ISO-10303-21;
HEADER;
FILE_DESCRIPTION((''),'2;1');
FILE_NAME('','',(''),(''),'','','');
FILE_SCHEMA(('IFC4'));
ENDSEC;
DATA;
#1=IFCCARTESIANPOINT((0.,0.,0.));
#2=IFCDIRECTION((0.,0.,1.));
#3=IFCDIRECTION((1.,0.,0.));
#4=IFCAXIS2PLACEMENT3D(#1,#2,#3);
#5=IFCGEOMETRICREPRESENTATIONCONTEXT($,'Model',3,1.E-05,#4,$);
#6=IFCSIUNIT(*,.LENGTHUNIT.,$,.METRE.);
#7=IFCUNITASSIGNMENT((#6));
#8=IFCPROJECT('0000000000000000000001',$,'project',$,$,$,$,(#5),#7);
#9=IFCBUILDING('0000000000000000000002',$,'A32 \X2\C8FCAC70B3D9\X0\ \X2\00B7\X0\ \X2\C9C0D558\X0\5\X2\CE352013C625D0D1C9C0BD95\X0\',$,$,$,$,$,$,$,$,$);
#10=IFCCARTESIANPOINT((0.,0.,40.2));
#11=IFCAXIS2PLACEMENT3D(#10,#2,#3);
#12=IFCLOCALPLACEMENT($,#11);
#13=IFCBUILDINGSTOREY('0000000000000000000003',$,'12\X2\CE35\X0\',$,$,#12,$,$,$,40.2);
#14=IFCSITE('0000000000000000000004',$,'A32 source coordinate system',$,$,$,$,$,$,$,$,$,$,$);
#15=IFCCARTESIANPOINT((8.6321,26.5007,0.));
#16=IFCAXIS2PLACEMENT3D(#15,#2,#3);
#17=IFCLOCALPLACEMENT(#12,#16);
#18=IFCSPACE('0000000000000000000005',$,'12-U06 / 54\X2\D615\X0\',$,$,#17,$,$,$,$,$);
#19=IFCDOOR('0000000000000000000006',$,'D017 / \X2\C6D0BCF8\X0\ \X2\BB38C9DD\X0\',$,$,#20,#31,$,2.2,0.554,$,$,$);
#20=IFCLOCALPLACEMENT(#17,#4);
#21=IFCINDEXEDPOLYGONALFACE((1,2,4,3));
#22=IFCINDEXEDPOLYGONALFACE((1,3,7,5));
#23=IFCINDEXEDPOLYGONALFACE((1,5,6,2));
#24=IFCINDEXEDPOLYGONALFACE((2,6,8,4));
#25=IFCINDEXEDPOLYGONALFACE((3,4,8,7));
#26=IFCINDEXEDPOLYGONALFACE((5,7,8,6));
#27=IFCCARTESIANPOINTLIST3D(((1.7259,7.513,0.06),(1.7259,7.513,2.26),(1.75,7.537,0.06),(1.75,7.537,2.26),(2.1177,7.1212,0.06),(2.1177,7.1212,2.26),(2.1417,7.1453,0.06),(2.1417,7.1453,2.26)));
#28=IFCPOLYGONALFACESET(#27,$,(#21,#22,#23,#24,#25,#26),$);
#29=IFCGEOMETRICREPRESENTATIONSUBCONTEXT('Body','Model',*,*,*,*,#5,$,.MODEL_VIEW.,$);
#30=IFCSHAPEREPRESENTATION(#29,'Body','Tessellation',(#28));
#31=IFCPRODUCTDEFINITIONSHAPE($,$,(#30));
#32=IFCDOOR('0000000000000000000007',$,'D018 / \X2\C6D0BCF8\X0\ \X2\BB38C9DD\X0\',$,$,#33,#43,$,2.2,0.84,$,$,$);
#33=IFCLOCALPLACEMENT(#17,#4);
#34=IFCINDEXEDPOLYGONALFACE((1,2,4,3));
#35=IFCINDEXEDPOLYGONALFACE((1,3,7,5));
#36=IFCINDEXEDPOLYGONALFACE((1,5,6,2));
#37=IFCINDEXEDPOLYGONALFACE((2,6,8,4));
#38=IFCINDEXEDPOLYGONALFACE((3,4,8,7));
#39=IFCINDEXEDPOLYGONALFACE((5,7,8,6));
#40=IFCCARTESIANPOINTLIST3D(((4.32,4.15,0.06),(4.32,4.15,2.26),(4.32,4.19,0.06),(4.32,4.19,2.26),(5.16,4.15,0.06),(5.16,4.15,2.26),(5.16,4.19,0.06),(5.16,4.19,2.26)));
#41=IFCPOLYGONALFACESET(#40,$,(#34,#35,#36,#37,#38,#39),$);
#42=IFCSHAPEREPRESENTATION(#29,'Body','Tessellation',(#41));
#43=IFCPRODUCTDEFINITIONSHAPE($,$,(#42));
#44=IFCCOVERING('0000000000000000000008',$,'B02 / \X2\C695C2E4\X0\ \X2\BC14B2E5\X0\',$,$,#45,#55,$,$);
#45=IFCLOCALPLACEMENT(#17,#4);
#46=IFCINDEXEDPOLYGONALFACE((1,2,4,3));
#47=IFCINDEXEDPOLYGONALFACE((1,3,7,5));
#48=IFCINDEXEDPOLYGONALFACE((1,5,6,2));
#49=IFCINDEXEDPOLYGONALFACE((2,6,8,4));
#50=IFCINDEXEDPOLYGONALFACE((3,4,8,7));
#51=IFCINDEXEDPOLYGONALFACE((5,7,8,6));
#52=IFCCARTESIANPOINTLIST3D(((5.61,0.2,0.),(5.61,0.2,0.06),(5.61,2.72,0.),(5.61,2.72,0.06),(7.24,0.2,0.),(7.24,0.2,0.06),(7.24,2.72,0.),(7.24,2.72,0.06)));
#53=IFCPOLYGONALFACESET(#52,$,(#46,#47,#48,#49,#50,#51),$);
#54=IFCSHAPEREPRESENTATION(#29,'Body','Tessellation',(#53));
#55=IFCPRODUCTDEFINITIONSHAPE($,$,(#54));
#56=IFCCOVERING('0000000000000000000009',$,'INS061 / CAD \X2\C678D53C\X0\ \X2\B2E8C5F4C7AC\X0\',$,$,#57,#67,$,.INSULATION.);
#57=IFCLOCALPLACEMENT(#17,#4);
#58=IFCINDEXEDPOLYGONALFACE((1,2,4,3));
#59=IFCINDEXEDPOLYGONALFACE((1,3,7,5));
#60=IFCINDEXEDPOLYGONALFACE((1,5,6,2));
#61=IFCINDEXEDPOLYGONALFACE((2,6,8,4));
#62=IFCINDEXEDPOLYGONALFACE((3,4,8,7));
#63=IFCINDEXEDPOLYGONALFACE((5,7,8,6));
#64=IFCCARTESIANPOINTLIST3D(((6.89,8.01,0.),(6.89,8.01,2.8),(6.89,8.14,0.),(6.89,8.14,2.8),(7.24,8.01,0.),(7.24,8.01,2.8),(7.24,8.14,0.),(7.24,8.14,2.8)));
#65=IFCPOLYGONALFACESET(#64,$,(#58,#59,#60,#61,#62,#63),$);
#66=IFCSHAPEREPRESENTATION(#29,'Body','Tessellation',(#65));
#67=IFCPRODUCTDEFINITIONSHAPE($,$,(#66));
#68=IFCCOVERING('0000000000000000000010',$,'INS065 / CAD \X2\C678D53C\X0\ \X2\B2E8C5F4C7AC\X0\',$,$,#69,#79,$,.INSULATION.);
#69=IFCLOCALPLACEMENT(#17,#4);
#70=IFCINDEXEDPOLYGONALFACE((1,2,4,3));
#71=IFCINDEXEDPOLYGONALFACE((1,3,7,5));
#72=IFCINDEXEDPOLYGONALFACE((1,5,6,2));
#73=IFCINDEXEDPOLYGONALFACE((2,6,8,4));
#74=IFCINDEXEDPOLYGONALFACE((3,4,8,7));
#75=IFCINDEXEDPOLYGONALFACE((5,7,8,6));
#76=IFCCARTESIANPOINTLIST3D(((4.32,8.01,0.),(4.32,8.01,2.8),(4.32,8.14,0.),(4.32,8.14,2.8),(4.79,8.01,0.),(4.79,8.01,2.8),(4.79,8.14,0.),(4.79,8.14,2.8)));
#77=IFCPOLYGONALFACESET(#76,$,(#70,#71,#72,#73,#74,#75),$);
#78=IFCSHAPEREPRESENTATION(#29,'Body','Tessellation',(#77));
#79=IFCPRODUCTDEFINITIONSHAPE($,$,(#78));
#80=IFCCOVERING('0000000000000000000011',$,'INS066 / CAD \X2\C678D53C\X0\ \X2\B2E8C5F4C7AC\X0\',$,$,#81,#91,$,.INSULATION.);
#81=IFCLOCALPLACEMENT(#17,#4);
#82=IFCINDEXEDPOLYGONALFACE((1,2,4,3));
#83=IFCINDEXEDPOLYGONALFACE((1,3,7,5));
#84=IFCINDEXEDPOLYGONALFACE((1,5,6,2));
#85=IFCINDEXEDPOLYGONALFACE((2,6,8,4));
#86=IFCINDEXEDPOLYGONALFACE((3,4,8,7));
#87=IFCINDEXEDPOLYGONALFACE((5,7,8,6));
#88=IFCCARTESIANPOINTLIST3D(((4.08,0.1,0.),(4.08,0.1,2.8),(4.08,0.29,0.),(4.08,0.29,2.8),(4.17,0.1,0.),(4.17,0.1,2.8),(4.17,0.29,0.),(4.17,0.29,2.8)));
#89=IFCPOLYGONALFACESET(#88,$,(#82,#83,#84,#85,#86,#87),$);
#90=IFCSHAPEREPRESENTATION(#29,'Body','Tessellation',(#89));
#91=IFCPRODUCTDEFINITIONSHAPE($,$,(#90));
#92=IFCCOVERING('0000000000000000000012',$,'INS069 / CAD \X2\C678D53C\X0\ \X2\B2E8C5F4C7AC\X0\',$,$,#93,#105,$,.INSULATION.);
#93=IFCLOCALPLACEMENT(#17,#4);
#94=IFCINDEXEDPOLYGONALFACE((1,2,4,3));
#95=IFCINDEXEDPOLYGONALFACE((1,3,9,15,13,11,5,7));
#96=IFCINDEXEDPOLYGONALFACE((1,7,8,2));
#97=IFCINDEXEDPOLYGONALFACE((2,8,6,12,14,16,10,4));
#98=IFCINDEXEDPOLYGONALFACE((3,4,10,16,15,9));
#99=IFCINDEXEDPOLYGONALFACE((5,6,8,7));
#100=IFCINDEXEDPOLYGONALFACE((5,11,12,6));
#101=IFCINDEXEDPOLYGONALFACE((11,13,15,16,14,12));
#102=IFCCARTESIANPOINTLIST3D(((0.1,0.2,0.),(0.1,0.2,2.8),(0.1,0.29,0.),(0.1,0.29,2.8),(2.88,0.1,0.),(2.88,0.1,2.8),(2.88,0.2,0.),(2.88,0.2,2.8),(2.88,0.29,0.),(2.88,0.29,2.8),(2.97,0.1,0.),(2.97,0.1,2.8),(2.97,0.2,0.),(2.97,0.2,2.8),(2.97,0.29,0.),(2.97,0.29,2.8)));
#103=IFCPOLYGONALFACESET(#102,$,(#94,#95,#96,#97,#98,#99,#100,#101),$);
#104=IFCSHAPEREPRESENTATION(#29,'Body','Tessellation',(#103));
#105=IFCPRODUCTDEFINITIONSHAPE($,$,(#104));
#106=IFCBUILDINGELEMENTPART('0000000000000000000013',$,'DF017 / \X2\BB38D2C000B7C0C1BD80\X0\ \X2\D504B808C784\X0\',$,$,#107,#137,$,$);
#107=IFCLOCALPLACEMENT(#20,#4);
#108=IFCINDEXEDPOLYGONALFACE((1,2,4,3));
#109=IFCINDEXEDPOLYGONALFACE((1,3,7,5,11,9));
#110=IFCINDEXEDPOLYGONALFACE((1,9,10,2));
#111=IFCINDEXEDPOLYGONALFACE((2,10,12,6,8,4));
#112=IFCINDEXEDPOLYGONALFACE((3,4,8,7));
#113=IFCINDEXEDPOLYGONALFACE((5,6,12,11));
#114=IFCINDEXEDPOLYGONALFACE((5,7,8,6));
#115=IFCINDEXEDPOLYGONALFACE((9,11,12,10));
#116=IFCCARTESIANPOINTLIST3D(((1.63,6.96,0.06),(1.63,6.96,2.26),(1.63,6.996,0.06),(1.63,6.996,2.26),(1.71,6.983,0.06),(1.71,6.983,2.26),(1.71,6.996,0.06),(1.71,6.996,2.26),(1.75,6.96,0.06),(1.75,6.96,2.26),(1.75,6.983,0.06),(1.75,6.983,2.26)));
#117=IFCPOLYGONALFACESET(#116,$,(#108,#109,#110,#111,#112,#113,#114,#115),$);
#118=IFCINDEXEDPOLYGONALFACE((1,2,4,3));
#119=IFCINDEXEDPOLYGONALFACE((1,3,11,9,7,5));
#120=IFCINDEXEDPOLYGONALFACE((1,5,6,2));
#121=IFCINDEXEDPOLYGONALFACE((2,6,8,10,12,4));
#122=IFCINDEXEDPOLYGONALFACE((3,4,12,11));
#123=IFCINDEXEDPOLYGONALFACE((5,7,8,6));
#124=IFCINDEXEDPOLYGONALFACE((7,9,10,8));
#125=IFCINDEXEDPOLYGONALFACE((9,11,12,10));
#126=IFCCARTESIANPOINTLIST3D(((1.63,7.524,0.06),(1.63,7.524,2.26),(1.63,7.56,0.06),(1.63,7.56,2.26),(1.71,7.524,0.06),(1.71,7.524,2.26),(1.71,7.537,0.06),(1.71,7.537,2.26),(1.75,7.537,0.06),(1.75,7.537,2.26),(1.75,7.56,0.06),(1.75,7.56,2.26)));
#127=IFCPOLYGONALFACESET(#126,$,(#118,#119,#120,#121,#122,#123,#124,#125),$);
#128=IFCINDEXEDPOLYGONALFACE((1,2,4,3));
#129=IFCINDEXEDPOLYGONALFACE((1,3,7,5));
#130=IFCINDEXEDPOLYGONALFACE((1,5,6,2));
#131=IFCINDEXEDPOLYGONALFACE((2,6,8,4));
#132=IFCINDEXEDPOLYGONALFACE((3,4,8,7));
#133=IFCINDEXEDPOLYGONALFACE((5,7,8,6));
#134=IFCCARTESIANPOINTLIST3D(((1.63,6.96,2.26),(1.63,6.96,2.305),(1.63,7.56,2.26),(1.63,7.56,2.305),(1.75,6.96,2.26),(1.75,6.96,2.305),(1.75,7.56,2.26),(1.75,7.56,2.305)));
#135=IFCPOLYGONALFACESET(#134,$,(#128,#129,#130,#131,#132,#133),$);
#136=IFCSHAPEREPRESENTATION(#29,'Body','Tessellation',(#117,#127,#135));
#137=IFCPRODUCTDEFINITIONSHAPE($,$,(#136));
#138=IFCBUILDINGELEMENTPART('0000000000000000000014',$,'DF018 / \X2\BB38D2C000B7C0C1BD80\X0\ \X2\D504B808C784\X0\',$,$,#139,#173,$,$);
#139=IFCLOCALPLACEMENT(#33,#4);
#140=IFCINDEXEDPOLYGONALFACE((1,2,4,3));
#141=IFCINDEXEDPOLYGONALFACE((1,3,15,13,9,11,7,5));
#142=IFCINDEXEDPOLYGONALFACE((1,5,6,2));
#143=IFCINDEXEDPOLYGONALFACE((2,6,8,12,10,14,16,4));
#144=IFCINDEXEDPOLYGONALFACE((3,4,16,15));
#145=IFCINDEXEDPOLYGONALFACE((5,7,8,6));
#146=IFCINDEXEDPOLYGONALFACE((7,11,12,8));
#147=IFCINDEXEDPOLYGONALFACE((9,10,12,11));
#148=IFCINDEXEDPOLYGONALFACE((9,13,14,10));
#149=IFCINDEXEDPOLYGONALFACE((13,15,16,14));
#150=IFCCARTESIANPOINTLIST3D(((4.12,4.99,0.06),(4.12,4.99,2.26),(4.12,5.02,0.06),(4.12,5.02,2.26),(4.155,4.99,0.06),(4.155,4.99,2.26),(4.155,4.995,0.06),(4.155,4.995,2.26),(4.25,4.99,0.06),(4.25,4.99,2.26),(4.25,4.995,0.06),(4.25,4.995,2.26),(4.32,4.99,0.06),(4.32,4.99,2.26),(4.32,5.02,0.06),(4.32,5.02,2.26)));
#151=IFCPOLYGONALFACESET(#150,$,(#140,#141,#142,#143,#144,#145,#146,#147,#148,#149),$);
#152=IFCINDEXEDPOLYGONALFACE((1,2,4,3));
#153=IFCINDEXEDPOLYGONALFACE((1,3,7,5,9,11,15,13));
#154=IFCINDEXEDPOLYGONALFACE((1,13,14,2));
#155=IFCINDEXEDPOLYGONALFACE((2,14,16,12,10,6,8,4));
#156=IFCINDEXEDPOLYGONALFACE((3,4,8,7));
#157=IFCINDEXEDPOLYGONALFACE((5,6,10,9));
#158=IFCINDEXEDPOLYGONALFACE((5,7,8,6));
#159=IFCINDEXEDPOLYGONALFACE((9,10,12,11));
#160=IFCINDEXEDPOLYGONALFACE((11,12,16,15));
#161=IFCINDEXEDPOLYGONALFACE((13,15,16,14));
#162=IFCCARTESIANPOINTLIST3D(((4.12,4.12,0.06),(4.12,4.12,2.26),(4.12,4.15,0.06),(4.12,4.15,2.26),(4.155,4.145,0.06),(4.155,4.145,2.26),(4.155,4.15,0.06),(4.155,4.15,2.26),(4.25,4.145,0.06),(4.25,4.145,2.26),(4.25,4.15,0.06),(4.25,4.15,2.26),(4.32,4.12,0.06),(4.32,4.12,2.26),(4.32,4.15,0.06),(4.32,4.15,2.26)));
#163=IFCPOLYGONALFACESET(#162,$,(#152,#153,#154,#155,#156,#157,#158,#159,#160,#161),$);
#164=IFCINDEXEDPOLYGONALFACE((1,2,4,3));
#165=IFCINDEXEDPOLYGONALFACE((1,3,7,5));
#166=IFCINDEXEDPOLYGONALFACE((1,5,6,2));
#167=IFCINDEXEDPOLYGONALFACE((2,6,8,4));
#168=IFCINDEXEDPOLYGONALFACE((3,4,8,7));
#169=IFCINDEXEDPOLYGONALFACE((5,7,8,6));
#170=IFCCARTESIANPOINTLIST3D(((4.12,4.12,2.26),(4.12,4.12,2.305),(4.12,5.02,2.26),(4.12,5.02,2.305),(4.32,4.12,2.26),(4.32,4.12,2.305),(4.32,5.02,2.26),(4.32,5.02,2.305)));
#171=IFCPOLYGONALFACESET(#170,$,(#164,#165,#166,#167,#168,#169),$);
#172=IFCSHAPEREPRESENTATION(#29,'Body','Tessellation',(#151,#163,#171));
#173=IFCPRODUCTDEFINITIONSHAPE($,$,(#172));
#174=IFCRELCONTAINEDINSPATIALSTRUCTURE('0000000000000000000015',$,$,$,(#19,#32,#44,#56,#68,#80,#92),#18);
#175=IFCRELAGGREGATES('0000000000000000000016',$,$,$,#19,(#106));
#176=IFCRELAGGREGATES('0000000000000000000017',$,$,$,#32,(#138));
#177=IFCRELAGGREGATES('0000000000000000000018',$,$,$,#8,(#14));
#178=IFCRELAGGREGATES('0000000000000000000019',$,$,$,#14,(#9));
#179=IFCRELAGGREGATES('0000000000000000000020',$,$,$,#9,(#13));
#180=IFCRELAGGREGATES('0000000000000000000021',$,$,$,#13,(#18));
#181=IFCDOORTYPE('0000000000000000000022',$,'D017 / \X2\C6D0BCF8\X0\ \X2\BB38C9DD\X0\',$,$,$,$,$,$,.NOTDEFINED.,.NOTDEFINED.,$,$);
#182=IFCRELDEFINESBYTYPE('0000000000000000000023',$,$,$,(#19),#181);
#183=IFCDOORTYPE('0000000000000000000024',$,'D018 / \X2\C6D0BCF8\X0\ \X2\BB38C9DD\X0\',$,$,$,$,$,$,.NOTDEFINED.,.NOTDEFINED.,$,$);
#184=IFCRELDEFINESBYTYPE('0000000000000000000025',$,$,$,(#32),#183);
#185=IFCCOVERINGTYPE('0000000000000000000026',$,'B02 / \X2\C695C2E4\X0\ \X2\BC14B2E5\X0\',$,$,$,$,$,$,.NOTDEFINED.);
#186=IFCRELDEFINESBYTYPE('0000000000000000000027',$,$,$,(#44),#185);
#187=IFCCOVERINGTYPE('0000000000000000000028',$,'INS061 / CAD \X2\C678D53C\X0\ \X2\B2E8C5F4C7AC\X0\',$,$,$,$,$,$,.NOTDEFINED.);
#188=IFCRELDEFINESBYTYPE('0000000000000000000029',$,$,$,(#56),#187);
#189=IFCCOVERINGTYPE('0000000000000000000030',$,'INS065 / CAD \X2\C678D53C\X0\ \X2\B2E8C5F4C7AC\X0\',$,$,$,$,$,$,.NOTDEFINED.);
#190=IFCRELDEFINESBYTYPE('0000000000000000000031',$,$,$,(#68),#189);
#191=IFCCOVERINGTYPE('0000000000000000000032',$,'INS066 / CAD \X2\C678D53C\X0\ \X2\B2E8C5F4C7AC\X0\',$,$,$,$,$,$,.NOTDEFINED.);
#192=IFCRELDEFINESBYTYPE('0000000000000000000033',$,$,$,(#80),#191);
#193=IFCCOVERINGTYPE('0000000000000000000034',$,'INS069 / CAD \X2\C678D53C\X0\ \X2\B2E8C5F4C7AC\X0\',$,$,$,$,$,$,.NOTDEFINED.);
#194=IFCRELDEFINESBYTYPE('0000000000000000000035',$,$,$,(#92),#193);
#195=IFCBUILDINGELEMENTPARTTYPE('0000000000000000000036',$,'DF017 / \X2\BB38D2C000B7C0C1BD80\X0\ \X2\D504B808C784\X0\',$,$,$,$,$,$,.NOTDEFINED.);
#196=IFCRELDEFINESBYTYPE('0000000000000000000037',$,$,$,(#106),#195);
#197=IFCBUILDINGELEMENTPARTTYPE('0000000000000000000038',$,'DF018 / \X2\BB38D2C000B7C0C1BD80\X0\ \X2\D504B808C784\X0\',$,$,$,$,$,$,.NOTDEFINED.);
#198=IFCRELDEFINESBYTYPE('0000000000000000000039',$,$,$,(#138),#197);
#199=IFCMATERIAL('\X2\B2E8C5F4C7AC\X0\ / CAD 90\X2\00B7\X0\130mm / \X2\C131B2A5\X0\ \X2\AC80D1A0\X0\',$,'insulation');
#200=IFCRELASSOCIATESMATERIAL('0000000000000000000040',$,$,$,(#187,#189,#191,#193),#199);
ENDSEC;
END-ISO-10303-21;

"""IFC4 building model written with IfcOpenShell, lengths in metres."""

from ifc_helpers import new_model, si_unit, frame, origin, origin_with_axes, place, context, subcontext, project, spatial, polyline, outline, extrude, source, transform, mapped, material, type_object, type_shapes, element, aggregate, save


model = new_model("IFC4")

# Units and contexts
model_context = context("Model", 3, precision=1e-05, world=origin_with_axes())
body_context = subcontext(model_context, "Body", "Model", "MODEL_VIEW")
ifc_project = project(units=[si_unit("LENGTHUNIT", "METRE")], contexts=[model_context])

# Site, building, storey, space
storey_placement = place(None, frame((0.0, 0.0, 40.2), z_axis=(0.0, 0.0, 1.0), x_axis=(1.0, 0.0, 0.0)))
space_1_placement = place(storey_placement, frame((8.6321, 26.5007, 0.0), z_axis=(0.0, 0.0, 1.0), x_axis=(1.0, 0.0, 0.0)))
site = spatial("IfcSite", under=ifc_project, Name="A32 source coordinate system")
building = spatial("IfcBuilding", under=site, Name="A32 주거동 · 지하5층–옥탑지붕")
storey = spatial("IfcBuildingStorey", under=building, at=storey_placement, Name="12층", Elevation=40.2)
space_1 = spatial("IfcSpace", under=storey, at=space_1_placement, Name="12-U06 / 54형")

# Doors
door_type_1 = type_object("IfcDoorType", Name="D017 / 원본 문짝", OperationType="NOTDEFINED", PredefinedType="NOTDEFINED")
shared_shape_1 = source(origin(), body_context, "Body", "SweptSolid", [
    extrude(outline(polyline([(1.75, 7.537), (2.1417, 7.1453), (2.1177, 7.1212), (1.7259, 7.513), (1.75, 7.537)])), frame((0.0, 0.0, 0.06)), (0.0, 0.0, 1.0), 2.2),
])
type_shapes(door_type_1, [shared_shape_1])
door_1_placement = place(space_1_placement, origin_with_axes())
door_1 = element("IfcDoor", 1, at=door_1_placement, inside=space_1, type_object=door_type_1, Name="D017 / 원본 문짝", OverallHeight=2.2, OverallWidth=0.554, context=body_context, shape_type="MappedRepresentation", body=[
    mapped(shared_shape_1, transform((0.0, 0.0, 0.0), scale=1.0)),
])
door_type_2 = type_object("IfcDoorType", Name="D018 / 원본 문짝", OperationType="NOTDEFINED", PredefinedType="NOTDEFINED")
shared_shape_2 = source(origin(), body_context, "Body", "SweptSolid", [
    extrude(outline(polyline([(5.16, 4.19), (5.16, 4.15), (4.32, 4.15), (4.32, 4.19), (5.16, 4.19)])), frame((0.0, 0.0, 0.06)), (0.0, 0.0, 1.0), 2.2),
])
type_shapes(door_type_2, [shared_shape_2])
door_2_placement = place(space_1_placement, origin_with_axes())
door_2 = element("IfcDoor", 2, at=door_2_placement, inside=space_1, type_object=door_type_2, Name="D018 / 원본 문짝", OverallHeight=2.2, OverallWidth=0.84, context=body_context, shape_type="MappedRepresentation", body=[
    mapped(shared_shape_2, transform((0.0, 0.0, 0.0), scale=1.0)),
])

# Coverings
covering_type_1 = type_object("IfcCoveringType", Name="B02 / 욕실 바닥", PredefinedType="NOTDEFINED")
shared_shape_3 = source(origin(), body_context, "Body", "SweptSolid", [
    extrude(outline(polyline([(5.61, 2.72), (7.24, 2.72), (7.24, 0.2), (5.61, 0.2), (5.61, 2.72)])), origin(), (0.0, 0.0, 1.0), 0.06),
])
type_shapes(covering_type_1, [shared_shape_3])
covering_1_placement = place(space_1_placement, origin_with_axes())
element("IfcCovering", 3, at=covering_1_placement, inside=space_1, type_object=covering_type_1, Name="B02 / 욕실 바닥", context=body_context, shape_type="MappedRepresentation", body=[
    mapped(shared_shape_3, transform((0.0, 0.0, 0.0), scale=1.0)),
])
ifc_material = material(Name="단열재 / CAD 90·130mm / 성능 검토", Category="insulation")
covering_type_2 = type_object("IfcCoveringType", Name="INS061 / CAD 외피 단열재", PredefinedType="NOTDEFINED", material=ifc_material)
shared_shape_4 = source(origin(), body_context, "Body", "SweptSolid", [
    extrude(outline(polyline([(6.89, 8.01), (6.89, 8.14), (7.24, 8.14), (7.24, 8.01), (6.89, 8.01)])), origin(), (0.0, 0.0, 1.0), 2.8),
])
type_shapes(covering_type_2, [shared_shape_4])
covering_2_placement = place(space_1_placement, origin_with_axes())
element("IfcCovering", 4, at=covering_2_placement, inside=space_1, type_object=covering_type_2, Name="INS061 / CAD 외피 단열재", PredefinedType="INSULATION", context=body_context, shape_type="MappedRepresentation", body=[
    mapped(shared_shape_4, transform((0.0, 0.0, 0.0), scale=1.0)),
])
covering_type_3 = type_object("IfcCoveringType", Name="INS065 / CAD 외피 단열재", PredefinedType="NOTDEFINED", material=ifc_material)
shared_shape_5 = source(origin(), body_context, "Body", "SweptSolid", [
    extrude(outline(polyline([(4.32, 8.01), (4.32, 8.14), (4.79, 8.14), (4.79, 8.01), (4.32, 8.01)])), origin(), (0.0, 0.0, 1.0), 2.8),
])
type_shapes(covering_type_3, [shared_shape_5])
covering_3_placement = place(space_1_placement, origin_with_axes())
element("IfcCovering", 5, at=covering_3_placement, inside=space_1, type_object=covering_type_3, Name="INS065 / CAD 외피 단열재", PredefinedType="INSULATION", context=body_context, shape_type="MappedRepresentation", body=[
    mapped(shared_shape_5, transform((0.0, 0.0, 0.0), scale=1.0)),
])
covering_type_4 = type_object("IfcCoveringType", Name="INS066 / CAD 외피 단열재", PredefinedType="NOTDEFINED", material=ifc_material)
shared_shape_6 = source(origin(), body_context, "Body", "SweptSolid", [
    extrude(outline(polyline([(4.08, 0.29), (4.17, 0.29), (4.17, 0.1), (4.08, 0.1), (4.08, 0.29)])), origin(), (0.0, 0.0, 1.0), 2.8),
])
type_shapes(covering_type_4, [shared_shape_6])
covering_4_placement = place(space_1_placement, origin_with_axes())
element("IfcCovering", 6, at=covering_4_placement, inside=space_1, type_object=covering_type_4, Name="INS066 / CAD 외피 단열재", PredefinedType="INSULATION", context=body_context, shape_type="MappedRepresentation", body=[
    mapped(shared_shape_6, transform((0.0, 0.0, 0.0), scale=1.0)),
])
covering_type_5 = type_object("IfcCoveringType", Name="INS069 / CAD 외피 단열재", PredefinedType="NOTDEFINED", material=ifc_material)
shared_shape_7 = source(origin(), body_context, "Body", "SweptSolid", [
    extrude(outline(polyline([(2.97, 0.1), (2.88, 0.1), (2.88, 0.2), (0.1, 0.2), (0.1, 0.29), (2.88, 0.29), (2.97, 0.29), (2.97, 0.2), (2.97, 0.1)])), origin(), (0.0, 0.0, 1.0), 2.8),
])
type_shapes(covering_type_5, [shared_shape_7])
covering_5_placement = place(space_1_placement, origin_with_axes())
element("IfcCovering", 7, at=covering_5_placement, inside=space_1, type_object=covering_type_5, Name="INS069 / CAD 외피 단열재", PredefinedType="INSULATION", context=body_context, shape_type="MappedRepresentation", body=[
    mapped(shared_shape_7, transform((0.0, 0.0, 0.0), scale=1.0)),
])

# Building element parts
building_element_part_type_1 = type_object("IfcBuildingElementPartType", Name="DF017 / 문틀·상부 프레임", PredefinedType="NOTDEFINED")
shared_shape_8 = source(origin(), body_context, "Body", "SweptSolid", [
    extrude(outline(polyline([(1.63, 6.996), (1.71, 6.996), (1.71, 6.983), (1.75, 6.983), (1.75, 6.96), (1.63, 6.96), (1.63, 6.996)])), frame((0.0, 0.0, 0.06)), (0.0, 0.0, 1.0), 2.2),
    extrude(outline(polyline([(1.75, 7.56), (1.75, 7.537), (1.71, 7.537), (1.71, 7.524), (1.63, 7.524), (1.63, 7.56), (1.75, 7.56)])), frame((0.0, 0.0, 0.06)), (0.0, 0.0, 1.0), 2.2),
    extrude(outline(polyline([(1.63, 6.96), (1.63, 7.56), (1.75, 7.56), (1.75, 6.96), (1.63, 6.96)])), frame((0.0, 0.0, 2.26)), (0.0, 0.0, 1.0), 0.045),
])
type_shapes(building_element_part_type_1, [shared_shape_8])
building_element_part_1_placement = place(door_1_placement, origin_with_axes())
building_element_part_1 = element("IfcBuildingElementPart", 8, at=building_element_part_1_placement, type_object=building_element_part_type_1, Name="DF017 / 문틀·상부 프레임", context=body_context, shape_type="MappedRepresentation", body=[
    mapped(shared_shape_8, transform((0.0, 0.0, 0.0), scale=1.0)),
])
aggregate(door_1, [building_element_part_1])
building_element_part_type_2 = type_object("IfcBuildingElementPartType", Name="DF018 / 문틀·상부 프레임", PredefinedType="NOTDEFINED")
shared_shape_9 = source(origin(), body_context, "Body", "SweptSolid", [
    extrude(outline(polyline([(4.32, 4.99), (4.25, 4.99), (4.25, 4.995), (4.155, 4.995), (4.155, 4.99), (4.12, 4.99), (4.12, 5.02), (4.32, 5.02), (4.32, 4.99)])), frame((0.0, 0.0, 0.06)), (0.0, 0.0, 1.0), 2.2),
    extrude(outline(polyline([(4.12, 4.12), (4.12, 4.15), (4.155, 4.15), (4.155, 4.145), (4.25, 4.145), (4.25, 4.15), (4.32, 4.15), (4.32, 4.12), (4.12, 4.12)])), frame((0.0, 0.0, 0.06)), (0.0, 0.0, 1.0), 2.2),
    extrude(outline(polyline([(4.12, 4.12), (4.12, 5.02), (4.32, 5.02), (4.32, 4.12), (4.12, 4.12)])), frame((0.0, 0.0, 2.26)), (0.0, 0.0, 1.0), 0.045),
])
type_shapes(building_element_part_type_2, [shared_shape_9])
building_element_part_2_placement = place(door_2_placement, origin_with_axes())
building_element_part_2 = element("IfcBuildingElementPart", 9, at=building_element_part_2_placement, type_object=building_element_part_type_2, Name="DF018 / 문틀·상부 프레임", context=body_context, shape_type="MappedRepresentation", body=[
    mapped(shared_shape_9, transform((0.0, 0.0, 0.0), scale=1.0)),
])
aggregate(door_2, [building_element_part_2])

save(model, "model.ifc")
